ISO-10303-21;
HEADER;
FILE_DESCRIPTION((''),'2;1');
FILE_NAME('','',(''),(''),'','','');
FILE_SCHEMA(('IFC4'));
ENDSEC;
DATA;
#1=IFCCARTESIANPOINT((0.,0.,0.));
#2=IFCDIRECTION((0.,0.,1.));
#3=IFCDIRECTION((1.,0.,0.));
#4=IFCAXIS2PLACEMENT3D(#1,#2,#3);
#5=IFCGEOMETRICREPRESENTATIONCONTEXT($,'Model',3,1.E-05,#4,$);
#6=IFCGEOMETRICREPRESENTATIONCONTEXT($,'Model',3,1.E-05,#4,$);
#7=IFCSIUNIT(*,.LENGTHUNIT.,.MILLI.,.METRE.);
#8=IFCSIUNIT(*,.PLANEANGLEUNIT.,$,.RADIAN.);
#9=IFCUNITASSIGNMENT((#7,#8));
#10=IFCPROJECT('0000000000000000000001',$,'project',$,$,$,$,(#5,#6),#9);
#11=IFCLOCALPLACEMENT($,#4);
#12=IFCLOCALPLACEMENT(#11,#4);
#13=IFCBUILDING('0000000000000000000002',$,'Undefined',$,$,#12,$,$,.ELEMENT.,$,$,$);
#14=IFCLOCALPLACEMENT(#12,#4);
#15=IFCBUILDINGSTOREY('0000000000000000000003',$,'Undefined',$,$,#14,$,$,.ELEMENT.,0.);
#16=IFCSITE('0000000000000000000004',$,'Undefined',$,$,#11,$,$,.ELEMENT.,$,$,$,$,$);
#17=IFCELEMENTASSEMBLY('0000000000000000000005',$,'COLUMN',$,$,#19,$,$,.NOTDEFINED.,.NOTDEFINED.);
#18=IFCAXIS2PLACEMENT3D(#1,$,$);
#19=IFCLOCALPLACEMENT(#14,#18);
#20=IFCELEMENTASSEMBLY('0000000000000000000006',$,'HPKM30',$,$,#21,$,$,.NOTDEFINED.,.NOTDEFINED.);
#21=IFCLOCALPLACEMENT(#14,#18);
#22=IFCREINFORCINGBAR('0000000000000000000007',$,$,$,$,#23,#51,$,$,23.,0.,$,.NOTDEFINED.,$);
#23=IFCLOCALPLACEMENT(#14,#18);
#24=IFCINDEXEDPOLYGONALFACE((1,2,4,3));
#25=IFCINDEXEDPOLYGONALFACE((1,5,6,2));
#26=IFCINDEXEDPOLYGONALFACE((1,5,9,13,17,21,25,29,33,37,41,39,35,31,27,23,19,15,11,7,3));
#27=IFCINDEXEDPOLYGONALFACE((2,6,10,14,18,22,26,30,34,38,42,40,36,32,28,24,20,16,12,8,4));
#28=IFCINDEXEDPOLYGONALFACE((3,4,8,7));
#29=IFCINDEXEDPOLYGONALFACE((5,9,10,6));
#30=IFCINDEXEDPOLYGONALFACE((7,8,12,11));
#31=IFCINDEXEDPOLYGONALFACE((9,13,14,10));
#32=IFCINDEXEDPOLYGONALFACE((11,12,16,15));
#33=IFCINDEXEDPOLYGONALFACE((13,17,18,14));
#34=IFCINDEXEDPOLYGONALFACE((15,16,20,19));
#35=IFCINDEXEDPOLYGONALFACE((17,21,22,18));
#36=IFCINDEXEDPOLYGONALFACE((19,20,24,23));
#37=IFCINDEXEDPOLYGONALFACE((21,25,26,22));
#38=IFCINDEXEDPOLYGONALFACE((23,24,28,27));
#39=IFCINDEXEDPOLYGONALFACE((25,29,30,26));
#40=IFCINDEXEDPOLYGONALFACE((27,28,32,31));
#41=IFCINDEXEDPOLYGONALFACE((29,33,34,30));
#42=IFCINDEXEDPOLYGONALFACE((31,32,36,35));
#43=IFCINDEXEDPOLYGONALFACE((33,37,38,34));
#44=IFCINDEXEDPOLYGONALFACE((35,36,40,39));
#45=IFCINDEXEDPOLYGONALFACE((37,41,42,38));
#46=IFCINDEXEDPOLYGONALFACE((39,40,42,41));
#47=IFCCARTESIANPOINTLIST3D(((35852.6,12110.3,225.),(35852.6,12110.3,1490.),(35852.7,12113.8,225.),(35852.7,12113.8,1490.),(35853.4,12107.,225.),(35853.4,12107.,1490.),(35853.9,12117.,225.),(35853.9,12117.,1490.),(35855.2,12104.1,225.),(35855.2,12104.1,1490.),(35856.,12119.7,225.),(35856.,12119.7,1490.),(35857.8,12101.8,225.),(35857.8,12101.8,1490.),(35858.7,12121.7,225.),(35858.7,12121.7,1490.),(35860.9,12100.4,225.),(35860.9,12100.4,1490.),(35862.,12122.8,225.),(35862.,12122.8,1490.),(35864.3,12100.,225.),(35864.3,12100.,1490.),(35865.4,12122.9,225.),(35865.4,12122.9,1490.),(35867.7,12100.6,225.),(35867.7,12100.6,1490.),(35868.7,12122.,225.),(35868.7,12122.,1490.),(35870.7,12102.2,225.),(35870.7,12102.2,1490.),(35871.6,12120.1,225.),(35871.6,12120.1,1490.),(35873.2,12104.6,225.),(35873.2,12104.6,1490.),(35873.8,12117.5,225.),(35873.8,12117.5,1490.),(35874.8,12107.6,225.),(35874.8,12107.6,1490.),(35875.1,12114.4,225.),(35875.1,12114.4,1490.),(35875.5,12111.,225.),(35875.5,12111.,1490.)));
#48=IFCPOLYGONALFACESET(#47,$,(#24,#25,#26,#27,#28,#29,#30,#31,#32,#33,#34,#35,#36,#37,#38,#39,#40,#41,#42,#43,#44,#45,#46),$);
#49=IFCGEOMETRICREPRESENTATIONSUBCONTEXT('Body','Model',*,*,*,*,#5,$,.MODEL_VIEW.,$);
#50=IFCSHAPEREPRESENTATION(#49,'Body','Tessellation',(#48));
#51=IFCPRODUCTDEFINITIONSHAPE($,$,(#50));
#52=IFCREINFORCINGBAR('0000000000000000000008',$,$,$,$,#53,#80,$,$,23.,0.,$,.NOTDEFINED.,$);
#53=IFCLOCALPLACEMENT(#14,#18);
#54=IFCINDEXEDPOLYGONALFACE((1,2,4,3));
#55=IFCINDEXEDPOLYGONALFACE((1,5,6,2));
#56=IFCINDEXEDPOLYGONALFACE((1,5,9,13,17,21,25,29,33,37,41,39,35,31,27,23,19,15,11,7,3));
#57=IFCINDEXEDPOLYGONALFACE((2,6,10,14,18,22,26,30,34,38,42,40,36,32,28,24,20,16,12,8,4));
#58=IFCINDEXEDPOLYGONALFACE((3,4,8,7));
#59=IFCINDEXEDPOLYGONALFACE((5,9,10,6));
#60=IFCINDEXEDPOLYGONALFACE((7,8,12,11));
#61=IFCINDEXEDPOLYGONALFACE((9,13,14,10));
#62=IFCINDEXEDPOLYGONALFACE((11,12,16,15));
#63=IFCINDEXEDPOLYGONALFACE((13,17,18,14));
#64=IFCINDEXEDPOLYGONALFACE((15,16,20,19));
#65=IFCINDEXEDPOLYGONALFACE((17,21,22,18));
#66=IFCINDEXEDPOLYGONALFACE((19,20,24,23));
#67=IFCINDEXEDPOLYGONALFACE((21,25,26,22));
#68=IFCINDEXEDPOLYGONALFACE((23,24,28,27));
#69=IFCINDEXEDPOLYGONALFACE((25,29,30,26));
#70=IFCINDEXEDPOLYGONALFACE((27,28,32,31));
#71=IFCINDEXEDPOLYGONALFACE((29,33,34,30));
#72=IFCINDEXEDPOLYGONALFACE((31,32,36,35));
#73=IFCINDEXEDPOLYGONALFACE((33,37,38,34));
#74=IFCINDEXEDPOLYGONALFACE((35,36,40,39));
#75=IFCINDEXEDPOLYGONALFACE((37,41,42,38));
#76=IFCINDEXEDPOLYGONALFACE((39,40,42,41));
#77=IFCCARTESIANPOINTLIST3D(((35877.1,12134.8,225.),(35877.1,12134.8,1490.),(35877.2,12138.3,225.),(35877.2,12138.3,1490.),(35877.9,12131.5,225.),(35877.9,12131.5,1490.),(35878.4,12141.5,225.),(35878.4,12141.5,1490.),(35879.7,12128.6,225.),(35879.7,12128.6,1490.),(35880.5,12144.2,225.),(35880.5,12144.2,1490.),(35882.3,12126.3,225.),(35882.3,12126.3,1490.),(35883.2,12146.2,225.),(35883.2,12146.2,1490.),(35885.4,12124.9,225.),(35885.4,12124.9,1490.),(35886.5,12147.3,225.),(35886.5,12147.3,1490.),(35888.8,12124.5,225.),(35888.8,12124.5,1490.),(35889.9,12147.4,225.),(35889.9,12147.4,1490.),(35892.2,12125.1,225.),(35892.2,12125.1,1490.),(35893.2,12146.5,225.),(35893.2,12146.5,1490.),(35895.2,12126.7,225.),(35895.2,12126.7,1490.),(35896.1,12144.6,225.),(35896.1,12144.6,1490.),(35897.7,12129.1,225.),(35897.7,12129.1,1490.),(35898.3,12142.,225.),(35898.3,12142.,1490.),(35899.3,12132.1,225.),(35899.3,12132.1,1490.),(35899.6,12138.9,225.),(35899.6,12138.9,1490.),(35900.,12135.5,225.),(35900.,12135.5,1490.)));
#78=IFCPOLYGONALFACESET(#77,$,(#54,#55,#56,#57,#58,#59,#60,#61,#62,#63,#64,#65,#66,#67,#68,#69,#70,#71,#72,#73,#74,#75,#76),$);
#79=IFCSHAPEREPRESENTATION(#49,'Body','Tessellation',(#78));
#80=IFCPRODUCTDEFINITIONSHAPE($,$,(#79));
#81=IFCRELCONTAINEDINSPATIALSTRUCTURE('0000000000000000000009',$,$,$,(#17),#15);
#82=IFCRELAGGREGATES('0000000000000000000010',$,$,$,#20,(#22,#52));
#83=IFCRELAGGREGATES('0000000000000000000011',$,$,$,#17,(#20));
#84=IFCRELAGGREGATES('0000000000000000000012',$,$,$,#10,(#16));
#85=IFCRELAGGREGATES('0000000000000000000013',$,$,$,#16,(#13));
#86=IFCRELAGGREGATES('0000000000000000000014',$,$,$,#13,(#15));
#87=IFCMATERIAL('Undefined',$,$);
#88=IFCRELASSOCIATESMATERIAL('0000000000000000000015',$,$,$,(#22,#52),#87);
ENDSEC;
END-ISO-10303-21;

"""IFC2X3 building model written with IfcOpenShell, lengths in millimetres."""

from ifc_helpers import new_model, entity, si_unit, frame, origin_with_axes, place, context, subcontext, project, spatial, source, transform, mapped, material, element, aggregate, save


model = new_model("IFC2X3")

# Units and contexts
model_context_1 = context("Model", 3, precision=1e-05, world=origin_with_axes())
model_context_2 = context("Model", 3, precision=1e-05, world=origin_with_axes())
body_context = subcontext(model_context_1, "Body", "Model", "MODEL_VIEW")
ifc_project = project(units=[si_unit("LENGTHUNIT", "METRE", prefix="MILLI"), si_unit("PLANEANGLEUNIT", "RADIAN")], contexts=[model_context_1, model_context_2])

# Site, building, storey
site_placement = place(None, origin_with_axes())
site = spatial("IfcSite", under=ifc_project, at=site_placement, Name="Undefined", CompositionType="ELEMENT")
building_placement = place(site_placement, origin_with_axes())
building = spatial("IfcBuilding", under=site, at=building_placement, Name="Undefined", CompositionType="ELEMENT")
storey_placement = place(building_placement, origin_with_axes())
storey = spatial("IfcBuildingStorey", under=building, at=storey_placement, Name="Undefined", CompositionType="ELEMENT", Elevation=0.0)

# Element assembly
assembly_1_placement = place(storey_placement, origin_with_axes())
assembly_1 = element("IfcElementAssembly", 1, at=assembly_1_placement, inside=storey, Name="COLUMN", AssemblyPlace="NOTDEFINED", PredefinedType="NOTDEFINED")
ifc_material_1 = material(Name="Undefined")

# Element assembly, reinforcing bars
assembly_2_placement = place(assembly_1_placement, origin_with_axes())
assembly_2 = element("IfcElementAssembly", 2, at=assembly_2_placement, Name="HPKM30", AssemblyPlace="NOTDEFINED", PredefinedType="NOTDEFINED")
shared_shape_1 = source(origin_with_axes(), body_context, "Body", "AdvancedSweptSolid", [
    entity("IfcSweptDiskSolid", entity("IfcTrimmedCurve", entity("IfcLine", entity("IfcCartesianPoint", [0.0, 0.0, 0.0]), entity("IfcVector", entity("IfcDirection", [1.0, 0.0, 0.0]), 1.0)), [entity("IfcParameterValue", 0.0)], [entity("IfcParameterValue", 1265.0)], True, "PARAMETER"), 11.5, None, 0.0, 1265.0),
])
reinforcing_bar_1_placement = place(assembly_2_placement, frame((35864.0, 12111.5, 225.0), z_axis=(0.320662, -0.947194, 0.0), x_axis=(0.0, 0.0, 1.0)))
reinforcing_bar_1 = element("IfcReinforcingBar", 3, at=reinforcing_bar_1_placement, material=ifc_material_1, BarRole="NOTDEFINED", CrossSectionArea=0.0, NominalDiameter=23.0, context=body_context, shape_type="MappedRepresentation", body=[
    mapped(shared_shape_1, transform((0.0, 0.0, 0.0))),
])
shared_shape_2 = source(origin_with_axes(), body_context, "Body", "AdvancedSweptSolid", [
    entity("IfcSweptDiskSolid", entity("IfcTrimmedCurve", entity("IfcLine", entity("IfcCartesianPoint", [0.0, 0.0, 0.0]), entity("IfcVector", entity("IfcDirection", [1.0, 0.0, 0.0]), 1.0)), [entity("IfcParameterValue", 0.0)], [entity("IfcParameterValue", 1265.0)], True, "PARAMETER"), 11.5, None, 0.0, 1265.0),
])
reinforcing_bar_2_placement = place(assembly_2_placement, frame((35888.5, 12136.0, 225.0), z_axis=(0.320662, -0.947194, 0.0), x_axis=(0.0, 0.0, 1.0)))
reinforcing_bar_2 = element("IfcReinforcingBar", 4, at=reinforcing_bar_2_placement, material=ifc_material_1, BarRole="NOTDEFINED", CrossSectionArea=0.0, NominalDiameter=23.0, context=body_context, shape_type="MappedRepresentation", body=[
    mapped(shared_shape_2, transform((0.0, 0.0, 0.0))),
])
aggregate(assembly_2, [reinforcing_bar_1, reinforcing_bar_2])

aggregate(assembly_1, [assembly_2])

save(model, "model.ifc")
